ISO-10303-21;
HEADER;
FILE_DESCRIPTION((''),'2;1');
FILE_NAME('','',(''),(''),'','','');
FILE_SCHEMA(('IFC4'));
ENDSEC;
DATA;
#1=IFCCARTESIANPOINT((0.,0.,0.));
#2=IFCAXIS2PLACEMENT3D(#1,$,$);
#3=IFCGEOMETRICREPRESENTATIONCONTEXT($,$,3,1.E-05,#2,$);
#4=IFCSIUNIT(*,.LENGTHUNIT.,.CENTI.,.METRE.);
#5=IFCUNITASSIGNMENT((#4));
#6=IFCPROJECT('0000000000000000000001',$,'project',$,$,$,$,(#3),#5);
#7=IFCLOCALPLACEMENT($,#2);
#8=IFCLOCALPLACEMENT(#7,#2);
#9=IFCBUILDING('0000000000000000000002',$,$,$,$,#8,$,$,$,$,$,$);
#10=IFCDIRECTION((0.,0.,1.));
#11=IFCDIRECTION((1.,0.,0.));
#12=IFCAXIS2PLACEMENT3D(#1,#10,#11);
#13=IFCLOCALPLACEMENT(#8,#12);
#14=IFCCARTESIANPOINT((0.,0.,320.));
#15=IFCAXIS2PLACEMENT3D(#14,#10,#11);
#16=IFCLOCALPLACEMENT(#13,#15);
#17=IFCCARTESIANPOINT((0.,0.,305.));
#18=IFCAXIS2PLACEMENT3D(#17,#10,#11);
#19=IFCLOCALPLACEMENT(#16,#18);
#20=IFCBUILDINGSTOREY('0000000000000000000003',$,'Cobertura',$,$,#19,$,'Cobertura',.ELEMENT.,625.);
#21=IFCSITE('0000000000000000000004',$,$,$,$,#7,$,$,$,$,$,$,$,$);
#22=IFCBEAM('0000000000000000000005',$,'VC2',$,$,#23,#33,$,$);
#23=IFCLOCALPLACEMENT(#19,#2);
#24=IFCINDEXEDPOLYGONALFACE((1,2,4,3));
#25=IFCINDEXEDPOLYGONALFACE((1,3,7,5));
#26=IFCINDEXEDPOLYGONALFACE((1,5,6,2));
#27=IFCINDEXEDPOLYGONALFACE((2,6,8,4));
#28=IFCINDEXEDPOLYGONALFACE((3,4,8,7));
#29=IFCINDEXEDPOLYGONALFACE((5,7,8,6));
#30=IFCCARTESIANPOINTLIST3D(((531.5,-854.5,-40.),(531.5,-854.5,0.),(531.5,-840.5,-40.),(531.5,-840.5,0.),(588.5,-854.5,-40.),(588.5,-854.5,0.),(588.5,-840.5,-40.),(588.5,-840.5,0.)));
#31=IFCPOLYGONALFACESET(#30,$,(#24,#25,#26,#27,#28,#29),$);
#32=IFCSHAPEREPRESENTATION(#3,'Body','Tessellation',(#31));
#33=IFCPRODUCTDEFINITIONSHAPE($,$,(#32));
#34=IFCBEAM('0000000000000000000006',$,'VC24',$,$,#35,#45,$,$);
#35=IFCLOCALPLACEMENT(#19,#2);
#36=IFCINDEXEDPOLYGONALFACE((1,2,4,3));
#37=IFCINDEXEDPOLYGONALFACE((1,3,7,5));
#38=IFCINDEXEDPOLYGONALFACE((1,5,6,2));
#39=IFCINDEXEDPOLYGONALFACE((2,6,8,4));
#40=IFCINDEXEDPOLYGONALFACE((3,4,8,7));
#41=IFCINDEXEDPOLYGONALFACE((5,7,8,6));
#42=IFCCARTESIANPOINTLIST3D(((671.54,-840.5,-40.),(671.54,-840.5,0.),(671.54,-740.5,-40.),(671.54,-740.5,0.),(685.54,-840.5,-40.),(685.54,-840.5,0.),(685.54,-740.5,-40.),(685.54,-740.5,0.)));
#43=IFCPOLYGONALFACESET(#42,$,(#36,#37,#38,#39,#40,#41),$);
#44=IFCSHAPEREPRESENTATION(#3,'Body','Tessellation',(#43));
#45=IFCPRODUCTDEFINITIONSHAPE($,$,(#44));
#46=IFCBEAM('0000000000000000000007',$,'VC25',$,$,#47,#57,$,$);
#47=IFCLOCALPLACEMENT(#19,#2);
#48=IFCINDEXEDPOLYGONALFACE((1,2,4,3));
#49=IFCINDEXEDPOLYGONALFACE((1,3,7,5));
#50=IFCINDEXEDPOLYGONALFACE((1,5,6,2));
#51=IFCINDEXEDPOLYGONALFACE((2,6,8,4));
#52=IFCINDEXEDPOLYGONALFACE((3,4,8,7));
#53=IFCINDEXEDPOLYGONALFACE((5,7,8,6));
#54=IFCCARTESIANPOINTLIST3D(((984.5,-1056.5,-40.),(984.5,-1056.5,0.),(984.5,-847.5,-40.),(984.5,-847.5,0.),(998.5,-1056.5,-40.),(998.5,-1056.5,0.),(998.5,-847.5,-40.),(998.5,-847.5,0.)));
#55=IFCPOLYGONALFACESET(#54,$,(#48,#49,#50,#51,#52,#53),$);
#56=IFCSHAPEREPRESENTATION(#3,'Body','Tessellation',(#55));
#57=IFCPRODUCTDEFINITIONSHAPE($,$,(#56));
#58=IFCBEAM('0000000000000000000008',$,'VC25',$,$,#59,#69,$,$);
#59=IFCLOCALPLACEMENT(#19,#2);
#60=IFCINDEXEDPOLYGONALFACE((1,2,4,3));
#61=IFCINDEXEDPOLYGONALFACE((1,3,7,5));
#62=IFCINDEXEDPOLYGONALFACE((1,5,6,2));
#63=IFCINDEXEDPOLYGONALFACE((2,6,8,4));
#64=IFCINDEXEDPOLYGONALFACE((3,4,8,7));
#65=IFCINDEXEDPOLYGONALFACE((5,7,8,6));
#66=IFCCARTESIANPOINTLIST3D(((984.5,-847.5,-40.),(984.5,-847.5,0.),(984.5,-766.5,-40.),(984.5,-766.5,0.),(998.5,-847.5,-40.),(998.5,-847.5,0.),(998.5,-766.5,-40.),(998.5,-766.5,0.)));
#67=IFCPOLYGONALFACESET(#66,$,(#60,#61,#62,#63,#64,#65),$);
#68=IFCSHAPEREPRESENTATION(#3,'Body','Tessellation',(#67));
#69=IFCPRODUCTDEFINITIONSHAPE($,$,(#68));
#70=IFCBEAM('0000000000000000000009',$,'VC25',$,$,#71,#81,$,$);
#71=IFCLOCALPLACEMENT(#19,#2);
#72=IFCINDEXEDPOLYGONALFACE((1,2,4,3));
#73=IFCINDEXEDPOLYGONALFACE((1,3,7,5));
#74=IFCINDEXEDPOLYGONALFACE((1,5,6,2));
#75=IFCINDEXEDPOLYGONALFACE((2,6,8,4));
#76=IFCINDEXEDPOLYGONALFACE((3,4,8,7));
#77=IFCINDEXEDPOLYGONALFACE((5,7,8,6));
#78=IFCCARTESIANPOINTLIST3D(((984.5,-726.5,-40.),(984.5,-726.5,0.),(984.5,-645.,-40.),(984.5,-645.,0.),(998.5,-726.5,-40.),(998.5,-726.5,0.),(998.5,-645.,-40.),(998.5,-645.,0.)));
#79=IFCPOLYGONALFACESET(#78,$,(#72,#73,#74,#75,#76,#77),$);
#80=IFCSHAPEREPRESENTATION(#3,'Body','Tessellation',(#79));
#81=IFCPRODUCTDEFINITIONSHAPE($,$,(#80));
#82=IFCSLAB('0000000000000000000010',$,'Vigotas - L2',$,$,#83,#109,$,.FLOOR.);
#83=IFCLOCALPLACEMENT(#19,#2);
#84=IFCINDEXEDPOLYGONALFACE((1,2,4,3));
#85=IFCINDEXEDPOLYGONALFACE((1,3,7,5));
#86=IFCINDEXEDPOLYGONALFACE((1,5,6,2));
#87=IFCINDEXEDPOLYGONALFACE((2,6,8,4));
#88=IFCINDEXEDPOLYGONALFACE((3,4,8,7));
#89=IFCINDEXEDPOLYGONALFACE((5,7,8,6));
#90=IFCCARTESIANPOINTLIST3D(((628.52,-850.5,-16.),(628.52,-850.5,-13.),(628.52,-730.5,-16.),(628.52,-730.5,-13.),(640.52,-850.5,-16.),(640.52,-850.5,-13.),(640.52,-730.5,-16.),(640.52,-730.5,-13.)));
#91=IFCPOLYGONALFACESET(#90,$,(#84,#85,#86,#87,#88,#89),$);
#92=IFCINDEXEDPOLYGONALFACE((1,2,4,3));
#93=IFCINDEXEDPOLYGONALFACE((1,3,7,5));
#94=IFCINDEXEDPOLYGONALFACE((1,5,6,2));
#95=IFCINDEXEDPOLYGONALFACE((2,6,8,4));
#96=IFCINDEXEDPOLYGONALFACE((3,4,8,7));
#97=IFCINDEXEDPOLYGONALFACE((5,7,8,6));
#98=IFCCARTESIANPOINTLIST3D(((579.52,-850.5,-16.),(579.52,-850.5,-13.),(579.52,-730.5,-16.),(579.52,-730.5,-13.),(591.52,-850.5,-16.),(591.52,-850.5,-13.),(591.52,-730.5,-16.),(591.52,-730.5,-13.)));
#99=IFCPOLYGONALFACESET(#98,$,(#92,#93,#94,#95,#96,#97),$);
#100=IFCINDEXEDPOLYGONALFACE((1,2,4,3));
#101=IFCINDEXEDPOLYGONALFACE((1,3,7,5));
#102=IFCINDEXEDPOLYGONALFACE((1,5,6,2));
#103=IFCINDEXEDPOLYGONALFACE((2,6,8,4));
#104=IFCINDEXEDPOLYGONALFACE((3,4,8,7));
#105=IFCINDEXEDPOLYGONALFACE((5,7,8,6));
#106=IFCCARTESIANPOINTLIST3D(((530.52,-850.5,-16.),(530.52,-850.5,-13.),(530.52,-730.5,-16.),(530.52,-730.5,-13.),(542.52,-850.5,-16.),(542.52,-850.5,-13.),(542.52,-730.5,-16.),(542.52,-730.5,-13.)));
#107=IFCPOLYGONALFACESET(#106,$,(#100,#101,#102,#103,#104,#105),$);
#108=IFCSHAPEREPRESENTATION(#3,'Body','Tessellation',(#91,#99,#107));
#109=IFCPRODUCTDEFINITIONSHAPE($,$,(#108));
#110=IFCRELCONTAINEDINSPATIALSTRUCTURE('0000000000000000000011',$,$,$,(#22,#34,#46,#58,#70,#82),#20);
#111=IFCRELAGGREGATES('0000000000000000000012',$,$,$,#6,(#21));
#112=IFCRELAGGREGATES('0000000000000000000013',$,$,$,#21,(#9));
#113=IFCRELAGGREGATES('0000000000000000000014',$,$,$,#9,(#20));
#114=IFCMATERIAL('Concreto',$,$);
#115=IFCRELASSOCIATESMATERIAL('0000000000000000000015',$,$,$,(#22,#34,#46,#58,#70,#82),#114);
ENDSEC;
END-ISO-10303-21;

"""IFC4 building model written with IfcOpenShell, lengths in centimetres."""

from ifc_helpers import new_model, si_unit, frame, origin, origin_with_axes, place, context, project, spatial, polyline, outline, extrude, material, element, save


model = new_model("IFC4")

# Units and contexts
context_of_model = context(None, 3, precision=1e-05, world=origin())
ifc_project = project(units=[si_unit("LENGTHUNIT", "METRE", prefix="CENTI")], contexts=[context_of_model])

# Site, building, storey
site_placement = place(None, origin())
site = spatial("IfcSite", under=ifc_project, at=site_placement)
building_placement = place(site_placement, origin())
building = spatial("IfcBuilding", under=site, at=building_placement)
placement_1 = place(building_placement, origin_with_axes())
placement_2 = place(placement_1, frame((0.0, 0.0, 320.0), z_axis=(0.0, 0.0, 1.0), x_axis=(1.0, 0.0, 0.0)))
storey_placement = place(placement_2, frame((0.0, 0.0, 305.0), z_axis=(0.0, 0.0, 1.0), x_axis=(1.0, 0.0, 0.0)))
storey = spatial("IfcBuildingStorey", under=building, at=storey_placement, Name="Cobertura", LongName="Cobertura", CompositionType="ELEMENT", Elevation=625.0)

# Shared definitions
ifc_material_1 = material(Name="Concreto")

# Beams
beam_1_placement = place(storey_placement, frame((560.0, -847.5, 0.0), z_axis=(0.0, 0.0, 1.0), x_axis=(1.0, 0.0, 0.0)))
element("IfcBeam", 1, at=beam_1_placement, inside=storey, material=ifc_material_1, Name="VC2", context=context_of_model, shape_type="SolidModel", body=[
    extrude(outline(polyline([(-7.0, -20.0), (7.0, -20.0), (7.0, 20.0), (-7.0, 20.0), (-7.0, -20.0)])), frame((-28.5, 0.0, -20.0), z_axis=(1.0, 0.0, 0.0), x_axis=(0.0, -1.0, 0.0)), (0.0, 0.0, 1.0), 57.0),
])
beam_2_placement = place(storey_placement, frame((678.54, -790.5, 0.0), z_axis=(0.0, 0.0, 1.0), x_axis=(1.0, 0.0, 0.0)))
element("IfcBeam", 2, at=beam_2_placement, inside=storey, material=ifc_material_1, Name="VC24", context=context_of_model, shape_type="SolidModel", body=[
    extrude(outline(polyline([(-7.0, -20.0), (7.0, -20.0), (7.0, 20.0), (-7.0, 20.0), (-7.0, -20.0)])), frame((0.0, -50.0, -20.0), z_axis=(0.0, 1.0, 0.0), x_axis=(1.0, 0.0, 0.0)), (0.0, 0.0, 1.0), 100.0),
])
beam_3_placement = place(storey_placement, frame((991.5, -952.0, 0.0), z_axis=(0.0, 0.0, 1.0), x_axis=(1.0, 0.0, 0.0)))
element("IfcBeam", 3, at=beam_3_placement, inside=storey, material=ifc_material_1, Name="VC25", context=context_of_model, shape_type="SolidModel", body=[
    extrude(outline(polyline([(-7.0, -20.0), (7.0, -20.0), (7.0, 20.0), (-7.0, 20.0), (-7.0, -20.0)])), frame((0.0, -104.5, -20.0), z_axis=(0.0, 1.0, 0.0), x_axis=(1.0, 0.0, 0.0)), (0.0, 0.0, 1.0), 209.0),
])
beam_4_placement = place(storey_placement, frame((991.5, -807.0, 0.0), z_axis=(0.0, 0.0, 1.0), x_axis=(1.0, 0.0, 0.0)))
element("IfcBeam", 4, at=beam_4_placement, inside=storey, material=ifc_material_1, Name="VC25", context=context_of_model, shape_type="SolidModel", body=[
    extrude(outline(polyline([(-7.0, -20.0), (7.0, -20.0), (7.0, 20.0), (-7.0, 20.0), (-7.0, -20.0)])), frame((0.0, -40.5, -20.0), z_axis=(0.0, 1.0, 0.0), x_axis=(1.0, 0.0, 0.0)), (0.0, 0.0, 1.0), 81.0),
])
beam_5_placement = place(storey_placement, frame((991.5, -685.75, 0.0), z_axis=(0.0, 0.0, 1.0), x_axis=(1.0, 0.0, 0.0)))
element("IfcBeam", 5, at=beam_5_placement, inside=storey, material=ifc_material_1, Name="VC25", context=context_of_model, shape_type="SolidModel", body=[
    extrude(outline(polyline([(-7.0, -20.0), (7.0, -20.0), (7.0, 20.0), (-7.0, 20.0), (-7.0, -20.0)])), frame((0.0, -40.75, -20.0), z_axis=(0.0, 1.0, 0.0), x_axis=(1.0, 0.0, 0.0)), (0.0, 0.0, 1.0), 81.5),
])

# Slab
slab_placement = place(storey_placement, frame((585.52, -790.5, -13.0), z_axis=(0.0, 0.0, 1.0), x_axis=(1.0, 0.0, 0.0)))
element("IfcSlab", 6, at=slab_placement, inside=storey, material=ifc_material_1, Name="Vigotas - L2", PredefinedType="FLOOR", context=context_of_model, shape_type="SolidModel", body=[
    extrude(outline(polyline([(6.0, 1.5), (-6.0, 1.5), (-6.0, -1.5), (6.0, -1.5), (6.0, 1.5), (6.0, 1.5)])), frame((49.0, -60.0, -1.5), z_axis=(0.0, 1.0, 0.0), x_axis=(1.0, 0.0, 0.0)), (0.0, 0.0, 1.0), 120.0),
    extrude(outline(polyline([(6.0, 1.5), (-6.0, 1.5), (-6.0, -1.5), (6.0, -1.5), (6.0, 1.5), (6.0, 1.5)])), frame((0.0, -60.0, -1.5), z_axis=(0.0, 1.0, 0.0), x_axis=(1.0, 0.0, 0.0)), (0.0, 0.0, 1.0), 120.0),
    extrude(outline(polyline([(6.0, 1.5), (-6.0, 1.5), (-6.0, -1.5), (6.0, -1.5), (6.0, 1.5), (6.0, 1.5)])), frame((-49.0, -60.0, -1.5), z_axis=(0.0, 1.0, 0.0), x_axis=(1.0, 0.0, 0.0)), (0.0, 0.0, 1.0), 120.0),
])

save(model, "model.ifc")
